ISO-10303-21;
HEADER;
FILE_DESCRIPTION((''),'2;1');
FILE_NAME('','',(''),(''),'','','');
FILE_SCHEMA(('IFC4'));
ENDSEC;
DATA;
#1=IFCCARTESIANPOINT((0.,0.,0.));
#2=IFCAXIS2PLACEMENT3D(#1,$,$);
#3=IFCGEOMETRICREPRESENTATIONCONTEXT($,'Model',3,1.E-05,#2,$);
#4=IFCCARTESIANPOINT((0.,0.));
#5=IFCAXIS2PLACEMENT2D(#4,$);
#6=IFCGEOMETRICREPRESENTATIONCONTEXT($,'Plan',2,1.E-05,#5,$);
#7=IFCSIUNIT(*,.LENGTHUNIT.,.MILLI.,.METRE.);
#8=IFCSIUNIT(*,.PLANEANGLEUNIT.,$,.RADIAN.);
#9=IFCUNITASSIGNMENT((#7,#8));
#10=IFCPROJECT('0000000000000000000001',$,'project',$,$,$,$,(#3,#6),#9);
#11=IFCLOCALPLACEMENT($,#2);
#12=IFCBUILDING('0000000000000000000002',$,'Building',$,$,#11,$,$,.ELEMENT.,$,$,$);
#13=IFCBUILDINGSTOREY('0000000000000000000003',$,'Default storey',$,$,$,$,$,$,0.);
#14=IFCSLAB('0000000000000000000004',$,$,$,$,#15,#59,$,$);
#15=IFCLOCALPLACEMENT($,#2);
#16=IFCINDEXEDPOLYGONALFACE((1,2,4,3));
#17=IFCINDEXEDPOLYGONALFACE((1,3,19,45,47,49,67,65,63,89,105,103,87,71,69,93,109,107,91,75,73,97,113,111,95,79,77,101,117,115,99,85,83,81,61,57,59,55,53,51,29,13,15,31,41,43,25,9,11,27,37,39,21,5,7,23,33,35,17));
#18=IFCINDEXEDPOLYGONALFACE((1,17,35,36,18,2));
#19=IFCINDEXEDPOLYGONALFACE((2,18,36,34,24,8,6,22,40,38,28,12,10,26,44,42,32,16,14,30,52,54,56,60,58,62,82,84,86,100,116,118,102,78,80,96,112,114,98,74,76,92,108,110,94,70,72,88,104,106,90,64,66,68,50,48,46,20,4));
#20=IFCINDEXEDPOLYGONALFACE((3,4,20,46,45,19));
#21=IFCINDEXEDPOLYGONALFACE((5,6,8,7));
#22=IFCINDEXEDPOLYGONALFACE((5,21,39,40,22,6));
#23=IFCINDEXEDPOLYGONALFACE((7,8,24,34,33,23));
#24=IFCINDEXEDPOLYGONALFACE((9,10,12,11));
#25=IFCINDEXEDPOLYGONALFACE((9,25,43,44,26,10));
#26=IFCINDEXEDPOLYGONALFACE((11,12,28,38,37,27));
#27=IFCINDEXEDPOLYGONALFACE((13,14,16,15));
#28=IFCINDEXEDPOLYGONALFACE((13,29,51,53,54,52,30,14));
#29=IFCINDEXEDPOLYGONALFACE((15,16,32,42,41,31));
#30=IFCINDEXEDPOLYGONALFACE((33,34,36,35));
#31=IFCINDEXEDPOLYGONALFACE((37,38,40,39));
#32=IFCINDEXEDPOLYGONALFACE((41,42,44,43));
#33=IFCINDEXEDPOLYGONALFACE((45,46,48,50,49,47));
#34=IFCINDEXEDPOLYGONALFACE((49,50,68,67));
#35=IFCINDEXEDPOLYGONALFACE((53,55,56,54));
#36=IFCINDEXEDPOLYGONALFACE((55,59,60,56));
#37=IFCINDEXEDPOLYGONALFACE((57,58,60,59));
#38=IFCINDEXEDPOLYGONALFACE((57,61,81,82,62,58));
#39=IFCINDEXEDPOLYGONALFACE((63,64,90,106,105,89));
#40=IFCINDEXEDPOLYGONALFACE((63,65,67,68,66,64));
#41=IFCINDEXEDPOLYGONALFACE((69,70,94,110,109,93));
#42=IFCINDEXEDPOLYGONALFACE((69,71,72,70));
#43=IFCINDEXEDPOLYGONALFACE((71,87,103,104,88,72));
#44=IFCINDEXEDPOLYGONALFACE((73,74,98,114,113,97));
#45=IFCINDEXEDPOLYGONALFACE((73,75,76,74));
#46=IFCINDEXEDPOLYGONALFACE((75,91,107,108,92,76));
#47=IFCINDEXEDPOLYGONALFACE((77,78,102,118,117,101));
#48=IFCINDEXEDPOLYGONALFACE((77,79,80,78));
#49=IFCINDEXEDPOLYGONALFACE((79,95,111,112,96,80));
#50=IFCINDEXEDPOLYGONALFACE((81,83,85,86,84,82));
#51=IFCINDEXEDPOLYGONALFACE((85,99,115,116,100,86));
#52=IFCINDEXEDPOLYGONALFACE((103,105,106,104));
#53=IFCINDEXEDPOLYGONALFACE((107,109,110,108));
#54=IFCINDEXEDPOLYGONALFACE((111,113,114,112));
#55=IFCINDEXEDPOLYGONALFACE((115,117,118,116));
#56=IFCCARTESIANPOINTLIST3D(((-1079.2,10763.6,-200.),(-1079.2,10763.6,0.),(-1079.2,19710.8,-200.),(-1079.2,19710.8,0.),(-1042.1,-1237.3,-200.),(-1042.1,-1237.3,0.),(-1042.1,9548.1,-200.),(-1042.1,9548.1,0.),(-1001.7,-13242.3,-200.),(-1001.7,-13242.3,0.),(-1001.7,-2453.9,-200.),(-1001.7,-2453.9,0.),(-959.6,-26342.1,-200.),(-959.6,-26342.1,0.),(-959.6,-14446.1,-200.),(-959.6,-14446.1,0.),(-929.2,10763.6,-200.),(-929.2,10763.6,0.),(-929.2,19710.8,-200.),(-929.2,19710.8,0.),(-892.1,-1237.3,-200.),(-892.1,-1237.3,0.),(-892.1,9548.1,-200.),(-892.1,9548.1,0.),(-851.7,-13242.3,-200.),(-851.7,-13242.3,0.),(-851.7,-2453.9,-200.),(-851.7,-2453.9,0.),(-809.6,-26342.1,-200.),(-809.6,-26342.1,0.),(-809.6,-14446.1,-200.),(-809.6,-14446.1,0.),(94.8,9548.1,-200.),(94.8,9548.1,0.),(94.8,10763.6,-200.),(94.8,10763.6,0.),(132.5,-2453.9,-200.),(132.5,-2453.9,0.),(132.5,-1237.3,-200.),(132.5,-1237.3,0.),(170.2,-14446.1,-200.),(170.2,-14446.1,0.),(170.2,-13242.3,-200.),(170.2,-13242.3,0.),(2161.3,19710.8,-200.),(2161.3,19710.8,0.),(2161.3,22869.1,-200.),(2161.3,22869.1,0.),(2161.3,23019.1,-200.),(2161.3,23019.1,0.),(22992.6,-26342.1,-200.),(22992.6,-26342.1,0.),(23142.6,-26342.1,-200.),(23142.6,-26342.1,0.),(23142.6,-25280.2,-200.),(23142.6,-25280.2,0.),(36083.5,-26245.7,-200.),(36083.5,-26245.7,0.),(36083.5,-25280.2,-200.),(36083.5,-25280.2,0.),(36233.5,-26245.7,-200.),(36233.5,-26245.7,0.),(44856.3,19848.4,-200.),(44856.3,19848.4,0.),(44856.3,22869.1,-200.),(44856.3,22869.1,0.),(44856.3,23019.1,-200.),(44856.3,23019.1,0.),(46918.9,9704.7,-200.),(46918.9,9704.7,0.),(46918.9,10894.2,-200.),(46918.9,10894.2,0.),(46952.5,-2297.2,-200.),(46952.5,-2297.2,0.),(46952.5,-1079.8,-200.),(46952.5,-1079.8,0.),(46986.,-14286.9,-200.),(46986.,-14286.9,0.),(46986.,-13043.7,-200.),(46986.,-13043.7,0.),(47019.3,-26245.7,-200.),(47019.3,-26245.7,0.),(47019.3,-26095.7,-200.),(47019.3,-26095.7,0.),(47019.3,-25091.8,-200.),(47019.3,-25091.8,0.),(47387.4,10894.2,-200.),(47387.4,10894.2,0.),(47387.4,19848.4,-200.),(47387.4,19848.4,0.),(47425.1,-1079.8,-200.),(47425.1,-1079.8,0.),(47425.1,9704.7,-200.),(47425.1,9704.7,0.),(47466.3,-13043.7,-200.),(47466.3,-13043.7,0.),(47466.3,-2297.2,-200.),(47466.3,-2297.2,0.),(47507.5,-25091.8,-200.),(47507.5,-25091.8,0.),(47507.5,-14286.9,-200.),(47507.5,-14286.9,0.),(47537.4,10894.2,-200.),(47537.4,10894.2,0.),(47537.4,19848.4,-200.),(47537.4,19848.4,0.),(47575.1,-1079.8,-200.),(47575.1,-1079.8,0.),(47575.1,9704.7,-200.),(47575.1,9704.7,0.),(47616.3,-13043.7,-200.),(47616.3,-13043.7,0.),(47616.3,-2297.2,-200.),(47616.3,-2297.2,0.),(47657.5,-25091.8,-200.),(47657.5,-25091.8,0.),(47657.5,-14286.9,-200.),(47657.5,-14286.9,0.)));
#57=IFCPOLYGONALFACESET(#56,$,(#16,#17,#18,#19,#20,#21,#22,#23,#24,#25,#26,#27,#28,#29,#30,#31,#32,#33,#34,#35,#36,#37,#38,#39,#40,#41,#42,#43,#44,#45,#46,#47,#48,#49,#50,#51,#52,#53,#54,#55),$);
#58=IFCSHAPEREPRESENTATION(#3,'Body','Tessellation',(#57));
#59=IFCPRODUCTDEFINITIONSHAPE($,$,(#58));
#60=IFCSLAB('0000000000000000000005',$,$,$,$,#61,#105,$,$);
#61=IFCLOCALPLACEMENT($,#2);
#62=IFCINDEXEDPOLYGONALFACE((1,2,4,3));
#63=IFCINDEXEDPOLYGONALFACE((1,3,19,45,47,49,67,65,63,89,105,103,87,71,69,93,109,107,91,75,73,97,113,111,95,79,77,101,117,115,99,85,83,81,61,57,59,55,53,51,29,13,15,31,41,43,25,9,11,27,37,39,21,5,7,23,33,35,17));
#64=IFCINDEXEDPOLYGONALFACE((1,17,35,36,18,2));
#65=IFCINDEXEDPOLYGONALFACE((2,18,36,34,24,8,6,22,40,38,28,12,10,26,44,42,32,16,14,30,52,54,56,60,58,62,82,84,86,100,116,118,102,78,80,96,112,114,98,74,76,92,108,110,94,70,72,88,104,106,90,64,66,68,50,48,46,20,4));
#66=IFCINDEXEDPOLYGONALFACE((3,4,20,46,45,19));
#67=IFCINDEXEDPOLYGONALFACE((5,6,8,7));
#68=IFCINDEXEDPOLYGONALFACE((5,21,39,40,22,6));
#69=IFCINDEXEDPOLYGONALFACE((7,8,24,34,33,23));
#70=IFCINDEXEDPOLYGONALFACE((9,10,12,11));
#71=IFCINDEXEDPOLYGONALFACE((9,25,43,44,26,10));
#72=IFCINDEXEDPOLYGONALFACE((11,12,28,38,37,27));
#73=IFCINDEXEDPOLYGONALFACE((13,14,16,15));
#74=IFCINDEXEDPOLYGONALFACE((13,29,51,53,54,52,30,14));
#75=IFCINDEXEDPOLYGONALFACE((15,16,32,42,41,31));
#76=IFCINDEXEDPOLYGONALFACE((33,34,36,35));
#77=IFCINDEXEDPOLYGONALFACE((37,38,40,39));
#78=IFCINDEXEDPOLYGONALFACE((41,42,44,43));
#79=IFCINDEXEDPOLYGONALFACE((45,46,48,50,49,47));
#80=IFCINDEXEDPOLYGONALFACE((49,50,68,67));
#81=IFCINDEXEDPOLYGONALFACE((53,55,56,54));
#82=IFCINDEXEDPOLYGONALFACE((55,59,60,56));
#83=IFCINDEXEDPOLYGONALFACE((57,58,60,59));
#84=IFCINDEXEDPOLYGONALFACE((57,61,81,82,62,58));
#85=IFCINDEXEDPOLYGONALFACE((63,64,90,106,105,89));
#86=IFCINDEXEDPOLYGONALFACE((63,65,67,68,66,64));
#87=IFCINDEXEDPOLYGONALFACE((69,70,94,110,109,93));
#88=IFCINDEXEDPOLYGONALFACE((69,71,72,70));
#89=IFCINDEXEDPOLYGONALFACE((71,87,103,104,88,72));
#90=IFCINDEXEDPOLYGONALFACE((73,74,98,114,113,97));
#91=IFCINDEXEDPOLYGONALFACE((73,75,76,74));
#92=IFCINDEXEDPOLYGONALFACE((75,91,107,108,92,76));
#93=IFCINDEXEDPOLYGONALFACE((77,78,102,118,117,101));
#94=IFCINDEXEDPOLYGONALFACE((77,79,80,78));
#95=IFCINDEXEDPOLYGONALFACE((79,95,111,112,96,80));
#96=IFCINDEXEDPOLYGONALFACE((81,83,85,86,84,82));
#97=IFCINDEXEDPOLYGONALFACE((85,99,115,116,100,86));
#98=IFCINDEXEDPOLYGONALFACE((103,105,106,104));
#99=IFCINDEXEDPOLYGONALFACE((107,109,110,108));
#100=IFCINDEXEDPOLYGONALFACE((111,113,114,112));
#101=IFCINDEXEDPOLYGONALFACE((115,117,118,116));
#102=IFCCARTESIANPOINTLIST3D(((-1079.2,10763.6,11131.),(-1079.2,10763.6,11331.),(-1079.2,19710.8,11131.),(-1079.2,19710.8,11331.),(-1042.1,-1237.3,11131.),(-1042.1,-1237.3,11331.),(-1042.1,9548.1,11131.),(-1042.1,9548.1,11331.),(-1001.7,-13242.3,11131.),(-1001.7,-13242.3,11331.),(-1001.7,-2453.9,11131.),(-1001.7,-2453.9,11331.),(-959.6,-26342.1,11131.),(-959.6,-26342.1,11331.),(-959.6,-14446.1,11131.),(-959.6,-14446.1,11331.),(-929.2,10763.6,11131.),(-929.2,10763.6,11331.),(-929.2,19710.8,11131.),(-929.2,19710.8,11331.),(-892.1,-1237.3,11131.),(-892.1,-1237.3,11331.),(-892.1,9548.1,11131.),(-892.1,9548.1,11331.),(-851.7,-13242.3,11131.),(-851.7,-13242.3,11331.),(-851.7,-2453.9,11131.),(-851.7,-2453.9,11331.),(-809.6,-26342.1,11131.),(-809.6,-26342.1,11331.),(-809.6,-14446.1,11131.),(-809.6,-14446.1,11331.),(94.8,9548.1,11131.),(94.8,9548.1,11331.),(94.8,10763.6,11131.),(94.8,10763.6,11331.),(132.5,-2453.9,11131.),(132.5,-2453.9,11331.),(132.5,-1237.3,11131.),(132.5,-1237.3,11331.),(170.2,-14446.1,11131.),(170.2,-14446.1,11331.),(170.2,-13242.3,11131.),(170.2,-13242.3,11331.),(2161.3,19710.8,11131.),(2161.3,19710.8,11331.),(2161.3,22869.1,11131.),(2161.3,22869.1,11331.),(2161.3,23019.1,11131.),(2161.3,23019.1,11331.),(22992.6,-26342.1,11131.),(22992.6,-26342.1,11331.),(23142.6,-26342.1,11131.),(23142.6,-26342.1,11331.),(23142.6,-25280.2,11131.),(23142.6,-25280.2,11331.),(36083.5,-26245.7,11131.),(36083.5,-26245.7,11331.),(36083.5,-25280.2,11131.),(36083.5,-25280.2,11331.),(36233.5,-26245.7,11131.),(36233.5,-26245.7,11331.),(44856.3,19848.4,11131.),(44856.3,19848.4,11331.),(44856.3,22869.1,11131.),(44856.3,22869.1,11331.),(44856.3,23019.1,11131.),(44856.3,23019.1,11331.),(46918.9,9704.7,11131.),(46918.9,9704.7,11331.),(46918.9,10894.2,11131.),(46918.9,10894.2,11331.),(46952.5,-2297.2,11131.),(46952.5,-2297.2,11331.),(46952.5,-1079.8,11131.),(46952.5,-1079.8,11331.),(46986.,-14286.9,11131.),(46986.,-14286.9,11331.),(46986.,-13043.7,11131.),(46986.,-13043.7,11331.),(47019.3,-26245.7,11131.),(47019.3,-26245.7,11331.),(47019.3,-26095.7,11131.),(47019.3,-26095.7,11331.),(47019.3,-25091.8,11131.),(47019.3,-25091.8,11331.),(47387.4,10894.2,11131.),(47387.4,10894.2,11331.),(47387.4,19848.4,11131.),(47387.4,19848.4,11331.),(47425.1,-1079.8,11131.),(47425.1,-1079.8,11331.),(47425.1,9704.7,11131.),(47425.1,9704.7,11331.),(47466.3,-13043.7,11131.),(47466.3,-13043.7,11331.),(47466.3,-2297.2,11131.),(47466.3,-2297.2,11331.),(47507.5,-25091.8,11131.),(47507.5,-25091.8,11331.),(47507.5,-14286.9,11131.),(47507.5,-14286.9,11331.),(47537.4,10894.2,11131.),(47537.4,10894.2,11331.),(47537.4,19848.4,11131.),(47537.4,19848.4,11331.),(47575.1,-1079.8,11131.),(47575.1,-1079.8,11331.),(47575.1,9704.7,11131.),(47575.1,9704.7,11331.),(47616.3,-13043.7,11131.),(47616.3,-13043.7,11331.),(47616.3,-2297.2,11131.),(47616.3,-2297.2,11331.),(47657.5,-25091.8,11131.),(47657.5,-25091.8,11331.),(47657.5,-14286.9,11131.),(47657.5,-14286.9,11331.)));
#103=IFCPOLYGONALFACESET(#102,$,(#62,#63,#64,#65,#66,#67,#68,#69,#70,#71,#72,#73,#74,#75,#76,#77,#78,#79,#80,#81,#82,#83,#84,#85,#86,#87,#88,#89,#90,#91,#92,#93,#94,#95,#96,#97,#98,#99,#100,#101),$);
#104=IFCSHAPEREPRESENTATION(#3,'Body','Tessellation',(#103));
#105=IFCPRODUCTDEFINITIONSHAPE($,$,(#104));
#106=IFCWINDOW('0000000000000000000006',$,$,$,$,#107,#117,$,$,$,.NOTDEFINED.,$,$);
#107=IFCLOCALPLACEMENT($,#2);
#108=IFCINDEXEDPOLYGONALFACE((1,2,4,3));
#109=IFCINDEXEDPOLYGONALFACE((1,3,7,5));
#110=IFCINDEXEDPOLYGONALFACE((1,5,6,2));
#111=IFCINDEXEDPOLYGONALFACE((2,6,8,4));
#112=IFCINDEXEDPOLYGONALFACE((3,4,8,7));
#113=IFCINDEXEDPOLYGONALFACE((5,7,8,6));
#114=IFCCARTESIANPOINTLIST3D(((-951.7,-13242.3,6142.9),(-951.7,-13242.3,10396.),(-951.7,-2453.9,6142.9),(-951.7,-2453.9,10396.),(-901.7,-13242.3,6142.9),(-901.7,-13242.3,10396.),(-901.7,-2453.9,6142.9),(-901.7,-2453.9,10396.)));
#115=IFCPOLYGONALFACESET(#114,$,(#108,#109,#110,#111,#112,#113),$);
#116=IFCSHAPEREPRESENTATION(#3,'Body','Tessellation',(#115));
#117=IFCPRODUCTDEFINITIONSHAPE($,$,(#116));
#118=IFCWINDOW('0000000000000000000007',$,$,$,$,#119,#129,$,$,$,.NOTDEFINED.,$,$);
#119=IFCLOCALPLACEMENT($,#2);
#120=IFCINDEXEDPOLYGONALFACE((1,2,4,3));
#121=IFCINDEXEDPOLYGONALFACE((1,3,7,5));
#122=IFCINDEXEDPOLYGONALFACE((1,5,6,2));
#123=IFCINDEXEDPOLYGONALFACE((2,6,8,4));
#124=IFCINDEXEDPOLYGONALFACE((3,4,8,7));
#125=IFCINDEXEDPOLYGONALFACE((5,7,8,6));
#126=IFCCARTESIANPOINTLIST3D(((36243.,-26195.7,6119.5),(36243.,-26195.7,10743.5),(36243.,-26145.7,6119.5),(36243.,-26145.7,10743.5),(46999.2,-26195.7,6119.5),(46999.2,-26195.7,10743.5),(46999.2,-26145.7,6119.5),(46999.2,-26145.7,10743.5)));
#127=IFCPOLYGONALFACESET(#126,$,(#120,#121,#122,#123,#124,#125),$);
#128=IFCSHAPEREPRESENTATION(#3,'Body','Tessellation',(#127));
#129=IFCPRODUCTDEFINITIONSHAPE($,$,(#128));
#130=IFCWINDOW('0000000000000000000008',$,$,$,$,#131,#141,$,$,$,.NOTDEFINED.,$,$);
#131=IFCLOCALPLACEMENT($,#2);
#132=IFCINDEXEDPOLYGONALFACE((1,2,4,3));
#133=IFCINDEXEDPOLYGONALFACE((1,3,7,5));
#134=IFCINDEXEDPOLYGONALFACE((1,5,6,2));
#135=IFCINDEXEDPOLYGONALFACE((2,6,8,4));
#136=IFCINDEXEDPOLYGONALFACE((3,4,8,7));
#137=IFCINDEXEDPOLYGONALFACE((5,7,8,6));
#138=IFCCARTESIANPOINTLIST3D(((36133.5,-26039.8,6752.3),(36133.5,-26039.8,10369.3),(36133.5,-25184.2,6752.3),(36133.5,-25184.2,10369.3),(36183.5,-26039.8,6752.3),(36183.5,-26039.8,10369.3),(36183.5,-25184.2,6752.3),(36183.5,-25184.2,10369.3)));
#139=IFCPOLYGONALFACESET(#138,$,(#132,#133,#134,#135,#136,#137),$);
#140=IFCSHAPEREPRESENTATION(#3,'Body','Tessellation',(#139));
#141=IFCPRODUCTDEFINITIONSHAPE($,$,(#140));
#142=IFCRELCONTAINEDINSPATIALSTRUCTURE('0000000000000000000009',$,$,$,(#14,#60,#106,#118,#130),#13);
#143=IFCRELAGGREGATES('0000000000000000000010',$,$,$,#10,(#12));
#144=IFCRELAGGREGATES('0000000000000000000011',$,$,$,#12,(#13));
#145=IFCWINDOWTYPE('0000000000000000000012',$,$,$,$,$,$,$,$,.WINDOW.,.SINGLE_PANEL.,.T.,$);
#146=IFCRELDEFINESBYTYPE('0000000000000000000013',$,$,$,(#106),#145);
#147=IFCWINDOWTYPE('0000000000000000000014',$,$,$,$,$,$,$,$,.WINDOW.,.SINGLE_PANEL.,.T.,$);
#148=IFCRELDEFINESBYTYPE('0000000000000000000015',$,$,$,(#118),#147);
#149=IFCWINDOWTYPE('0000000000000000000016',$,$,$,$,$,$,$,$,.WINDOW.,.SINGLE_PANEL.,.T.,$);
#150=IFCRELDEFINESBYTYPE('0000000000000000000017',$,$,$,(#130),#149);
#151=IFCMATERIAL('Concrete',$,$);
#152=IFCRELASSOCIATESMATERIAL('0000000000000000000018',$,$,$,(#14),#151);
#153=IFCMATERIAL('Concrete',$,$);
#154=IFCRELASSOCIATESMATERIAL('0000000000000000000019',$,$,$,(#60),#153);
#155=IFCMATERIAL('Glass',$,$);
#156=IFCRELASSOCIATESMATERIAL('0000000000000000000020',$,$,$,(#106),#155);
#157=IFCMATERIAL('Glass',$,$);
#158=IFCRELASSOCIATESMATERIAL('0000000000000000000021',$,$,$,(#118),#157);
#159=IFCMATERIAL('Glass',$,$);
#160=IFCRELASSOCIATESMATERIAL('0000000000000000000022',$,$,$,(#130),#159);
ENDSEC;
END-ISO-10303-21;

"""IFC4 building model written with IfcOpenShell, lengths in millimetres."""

from ifc_helpers import new_model, si_unit, frame, origin, origin_2d, place, context, project, spatial, polyline, rectangle, outline, extrude, material, type_object, element, save


model = new_model("IFC4")

# Units and contexts
model_context = context("Model", 3, precision=1e-05, world=origin())
plan_context = context("Plan", 2, precision=1e-05, world=origin_2d())
ifc_project = project(units=[si_unit("LENGTHUNIT", "METRE", prefix="MILLI"), si_unit("PLANEANGLEUNIT", "RADIAN")], contexts=[model_context, plan_context])

# Building, storey
placement = place(None, origin())
building = spatial("IfcBuilding", under=ifc_project, at=placement, Name="Building", CompositionType="ELEMENT")
storey = spatial("IfcBuildingStorey", under=building, Name="Default storey", Elevation=0.0)

# Slabs
ifc_material_1 = material(Name="Concrete")
element("IfcSlab", 1, at=placement, inside=storey, material=ifc_material_1, context=model_context, shape_type="SweptSolid", body=[
    extrude(outline(polyline([(46986.0, -14286.9), (46986.0, -13043.7), (47466.3, -13043.7), (47616.3, -13043.7), (47616.3, -2297.2), (47466.3, -2297.2), (46952.5, -2297.2), (46952.5, -1079.8), (47425.1, -1079.8), (47575.1, -1079.8), (47575.1, 9704.7), (47425.1, 9704.7), (46918.9, 9704.7), (46918.9, 10894.2), (47387.4, 10894.2), (47537.4, 10894.2), (47537.4, 19848.4), (47387.4, 19848.4), (44856.3, 19848.4), (44856.3, 22869.1), (44856.3, 23019.1), (2161.3, 23019.1), (2161.3, 22869.1), (2161.3, 19710.8), (-929.2, 19710.8), (-1079.2, 19710.8), (-1079.2, 10763.6), (-929.2, 10763.6), (94.8, 10763.6), (94.8, 9548.1), (-892.1, 9548.1), (-1042.1, 9548.1), (-1042.1, -1237.3), (-892.1, -1237.3), (132.5, -1237.3), (132.5, -2453.9), (-851.7, -2453.9), (-1001.7, -2453.9), (-1001.7, -13242.3), (-851.7, -13242.3), (170.2, -13242.3), (170.2, -14446.1), (-809.6, -14446.1), (-959.6, -14446.1), (-959.6, -26342.1), (-809.6, -26342.1), (22992.6, -26342.1), (23142.6, -26342.1), (23142.6, -25280.2), (36083.5, -25280.2), (36083.5, -26245.7), (36233.5, -26245.7), (47019.3, -26245.7), (47019.3, -26095.7), (47019.3, -25091.8), (47507.5, -25091.8), (47657.5, -25091.8), (47657.5, -14286.9), (47507.5, -14286.9), (46986.0, -14286.9)])), frame((0.0, 0.0, -200.0), z_axis=(0.0, 0.0, 1000.0), x_axis=(1000.0, 0.0, 0.0)), (0.0, 0.0, 1.0), 200.0),
])
ifc_material_2 = material(Name="Concrete")
element("IfcSlab", 2, at=placement, inside=storey, material=ifc_material_2, context=model_context, shape_type="SweptSolid", body=[
    extrude(outline(polyline([(46986.0, -14286.9), (46986.0, -13043.7), (47466.3, -13043.7), (47616.3, -13043.7), (47616.3, -2297.2), (47466.3, -2297.2), (46952.5, -2297.2), (46952.5, -1079.8), (47425.1, -1079.8), (47575.1, -1079.8), (47575.1, 9704.7), (47425.1, 9704.7), (46918.9, 9704.7), (46918.9, 10894.2), (47387.4, 10894.2), (47537.4, 10894.2), (47537.4, 19848.4), (47387.4, 19848.4), (44856.3, 19848.4), (44856.3, 22869.1), (44856.3, 23019.1), (2161.3, 23019.1), (2161.3, 22869.1), (2161.3, 19710.8), (-929.2, 19710.8), (-1079.2, 19710.8), (-1079.2, 10763.6), (-929.2, 10763.6), (94.8, 10763.6), (94.8, 9548.1), (-892.1, 9548.1), (-1042.1, 9548.1), (-1042.1, -1237.3), (-892.1, -1237.3), (132.5, -1237.3), (132.5, -2453.9), (-851.7, -2453.9), (-1001.7, -2453.9), (-1001.7, -13242.3), (-851.7, -13242.3), (170.2, -13242.3), (170.2, -14446.1), (-809.6, -14446.1), (-959.6, -14446.1), (-959.6, -26342.1), (-809.6, -26342.1), (22992.6, -26342.1), (23142.6, -26342.1), (23142.6, -25280.2), (36083.5, -25280.2), (36083.5, -26245.7), (36233.5, -26245.7), (47019.3, -26245.7), (47019.3, -26095.7), (47019.3, -25091.8), (47507.5, -25091.8), (47657.5, -25091.8), (47657.5, -14286.9), (47507.5, -14286.9), (46986.0, -14286.9)])), frame((0.0, 0.0, 11131.0), z_axis=(0.0, 0.0, 1000.0), x_axis=(1000.0, 0.0, 0.0)), (0.0, 0.0, 1.0), 200.0),
])

# Windows
ifc_material_3 = material(Name="Glass")
window_type_1 = type_object("IfcWindowType", ParameterTakesPrecedence=True, PartitioningType="SINGLE_PANEL", PredefinedType="WINDOW")
element("IfcWindow", 3, at=placement, inside=storey, type_object=window_type_1, material=ifc_material_3, PredefinedType="NOTDEFINED", context=model_context, shape_type="CSG", body=[
    extrude(rectangle(XDim=10788.4, YDim=50.0, at=origin_2d()), frame((-926.7, -7848.1, 6142.9), z_axis=(0.0, 0.0, 1000.0), x_axis=(0.0, 10788.419962, 0.0)), (0.0, 0.0, 1.0), 4253.1),
])
ifc_material_4 = material(Name="Glass")
window_type_2 = type_object("IfcWindowType", ParameterTakesPrecedence=True, PartitioningType="SINGLE_PANEL", PredefinedType="WINDOW")
element("IfcWindow", 4, at=placement, inside=storey, type_object=window_type_2, material=ifc_material_4, PredefinedType="NOTDEFINED", context=model_context, shape_type="CSG", body=[
    extrude(rectangle(XDim=10756.2, YDim=50.0, at=origin_2d()), frame((41621.1, -26170.7, 6119.5), z_axis=(0.0, 0.0, 1000.0), x_axis=(10756.198883, 0.0, 0.0)), (0.0, 0.0, 1.0), 4624.0),
])
ifc_material_5 = material(Name="Glass")
window_type_3 = type_object("IfcWindowType", ParameterTakesPrecedence=True, PartitioningType="SINGLE_PANEL", PredefinedType="WINDOW")
element("IfcWindow", 5, at=placement, inside=storey, type_object=window_type_3, material=ifc_material_5, PredefinedType="NOTDEFINED", context=model_context, shape_type="CSG", body=[
    extrude(rectangle(XDim=855.6, YDim=50.0, at=origin_2d()), frame((36158.5, -25612.0, 6752.3), z_axis=(0.0, 0.0, 1000.0), x_axis=(0.0, 855.600357, 0.0)), (0.0, 0.0, 1.0), 3617.0),
])

save(model, "model.ifc")
